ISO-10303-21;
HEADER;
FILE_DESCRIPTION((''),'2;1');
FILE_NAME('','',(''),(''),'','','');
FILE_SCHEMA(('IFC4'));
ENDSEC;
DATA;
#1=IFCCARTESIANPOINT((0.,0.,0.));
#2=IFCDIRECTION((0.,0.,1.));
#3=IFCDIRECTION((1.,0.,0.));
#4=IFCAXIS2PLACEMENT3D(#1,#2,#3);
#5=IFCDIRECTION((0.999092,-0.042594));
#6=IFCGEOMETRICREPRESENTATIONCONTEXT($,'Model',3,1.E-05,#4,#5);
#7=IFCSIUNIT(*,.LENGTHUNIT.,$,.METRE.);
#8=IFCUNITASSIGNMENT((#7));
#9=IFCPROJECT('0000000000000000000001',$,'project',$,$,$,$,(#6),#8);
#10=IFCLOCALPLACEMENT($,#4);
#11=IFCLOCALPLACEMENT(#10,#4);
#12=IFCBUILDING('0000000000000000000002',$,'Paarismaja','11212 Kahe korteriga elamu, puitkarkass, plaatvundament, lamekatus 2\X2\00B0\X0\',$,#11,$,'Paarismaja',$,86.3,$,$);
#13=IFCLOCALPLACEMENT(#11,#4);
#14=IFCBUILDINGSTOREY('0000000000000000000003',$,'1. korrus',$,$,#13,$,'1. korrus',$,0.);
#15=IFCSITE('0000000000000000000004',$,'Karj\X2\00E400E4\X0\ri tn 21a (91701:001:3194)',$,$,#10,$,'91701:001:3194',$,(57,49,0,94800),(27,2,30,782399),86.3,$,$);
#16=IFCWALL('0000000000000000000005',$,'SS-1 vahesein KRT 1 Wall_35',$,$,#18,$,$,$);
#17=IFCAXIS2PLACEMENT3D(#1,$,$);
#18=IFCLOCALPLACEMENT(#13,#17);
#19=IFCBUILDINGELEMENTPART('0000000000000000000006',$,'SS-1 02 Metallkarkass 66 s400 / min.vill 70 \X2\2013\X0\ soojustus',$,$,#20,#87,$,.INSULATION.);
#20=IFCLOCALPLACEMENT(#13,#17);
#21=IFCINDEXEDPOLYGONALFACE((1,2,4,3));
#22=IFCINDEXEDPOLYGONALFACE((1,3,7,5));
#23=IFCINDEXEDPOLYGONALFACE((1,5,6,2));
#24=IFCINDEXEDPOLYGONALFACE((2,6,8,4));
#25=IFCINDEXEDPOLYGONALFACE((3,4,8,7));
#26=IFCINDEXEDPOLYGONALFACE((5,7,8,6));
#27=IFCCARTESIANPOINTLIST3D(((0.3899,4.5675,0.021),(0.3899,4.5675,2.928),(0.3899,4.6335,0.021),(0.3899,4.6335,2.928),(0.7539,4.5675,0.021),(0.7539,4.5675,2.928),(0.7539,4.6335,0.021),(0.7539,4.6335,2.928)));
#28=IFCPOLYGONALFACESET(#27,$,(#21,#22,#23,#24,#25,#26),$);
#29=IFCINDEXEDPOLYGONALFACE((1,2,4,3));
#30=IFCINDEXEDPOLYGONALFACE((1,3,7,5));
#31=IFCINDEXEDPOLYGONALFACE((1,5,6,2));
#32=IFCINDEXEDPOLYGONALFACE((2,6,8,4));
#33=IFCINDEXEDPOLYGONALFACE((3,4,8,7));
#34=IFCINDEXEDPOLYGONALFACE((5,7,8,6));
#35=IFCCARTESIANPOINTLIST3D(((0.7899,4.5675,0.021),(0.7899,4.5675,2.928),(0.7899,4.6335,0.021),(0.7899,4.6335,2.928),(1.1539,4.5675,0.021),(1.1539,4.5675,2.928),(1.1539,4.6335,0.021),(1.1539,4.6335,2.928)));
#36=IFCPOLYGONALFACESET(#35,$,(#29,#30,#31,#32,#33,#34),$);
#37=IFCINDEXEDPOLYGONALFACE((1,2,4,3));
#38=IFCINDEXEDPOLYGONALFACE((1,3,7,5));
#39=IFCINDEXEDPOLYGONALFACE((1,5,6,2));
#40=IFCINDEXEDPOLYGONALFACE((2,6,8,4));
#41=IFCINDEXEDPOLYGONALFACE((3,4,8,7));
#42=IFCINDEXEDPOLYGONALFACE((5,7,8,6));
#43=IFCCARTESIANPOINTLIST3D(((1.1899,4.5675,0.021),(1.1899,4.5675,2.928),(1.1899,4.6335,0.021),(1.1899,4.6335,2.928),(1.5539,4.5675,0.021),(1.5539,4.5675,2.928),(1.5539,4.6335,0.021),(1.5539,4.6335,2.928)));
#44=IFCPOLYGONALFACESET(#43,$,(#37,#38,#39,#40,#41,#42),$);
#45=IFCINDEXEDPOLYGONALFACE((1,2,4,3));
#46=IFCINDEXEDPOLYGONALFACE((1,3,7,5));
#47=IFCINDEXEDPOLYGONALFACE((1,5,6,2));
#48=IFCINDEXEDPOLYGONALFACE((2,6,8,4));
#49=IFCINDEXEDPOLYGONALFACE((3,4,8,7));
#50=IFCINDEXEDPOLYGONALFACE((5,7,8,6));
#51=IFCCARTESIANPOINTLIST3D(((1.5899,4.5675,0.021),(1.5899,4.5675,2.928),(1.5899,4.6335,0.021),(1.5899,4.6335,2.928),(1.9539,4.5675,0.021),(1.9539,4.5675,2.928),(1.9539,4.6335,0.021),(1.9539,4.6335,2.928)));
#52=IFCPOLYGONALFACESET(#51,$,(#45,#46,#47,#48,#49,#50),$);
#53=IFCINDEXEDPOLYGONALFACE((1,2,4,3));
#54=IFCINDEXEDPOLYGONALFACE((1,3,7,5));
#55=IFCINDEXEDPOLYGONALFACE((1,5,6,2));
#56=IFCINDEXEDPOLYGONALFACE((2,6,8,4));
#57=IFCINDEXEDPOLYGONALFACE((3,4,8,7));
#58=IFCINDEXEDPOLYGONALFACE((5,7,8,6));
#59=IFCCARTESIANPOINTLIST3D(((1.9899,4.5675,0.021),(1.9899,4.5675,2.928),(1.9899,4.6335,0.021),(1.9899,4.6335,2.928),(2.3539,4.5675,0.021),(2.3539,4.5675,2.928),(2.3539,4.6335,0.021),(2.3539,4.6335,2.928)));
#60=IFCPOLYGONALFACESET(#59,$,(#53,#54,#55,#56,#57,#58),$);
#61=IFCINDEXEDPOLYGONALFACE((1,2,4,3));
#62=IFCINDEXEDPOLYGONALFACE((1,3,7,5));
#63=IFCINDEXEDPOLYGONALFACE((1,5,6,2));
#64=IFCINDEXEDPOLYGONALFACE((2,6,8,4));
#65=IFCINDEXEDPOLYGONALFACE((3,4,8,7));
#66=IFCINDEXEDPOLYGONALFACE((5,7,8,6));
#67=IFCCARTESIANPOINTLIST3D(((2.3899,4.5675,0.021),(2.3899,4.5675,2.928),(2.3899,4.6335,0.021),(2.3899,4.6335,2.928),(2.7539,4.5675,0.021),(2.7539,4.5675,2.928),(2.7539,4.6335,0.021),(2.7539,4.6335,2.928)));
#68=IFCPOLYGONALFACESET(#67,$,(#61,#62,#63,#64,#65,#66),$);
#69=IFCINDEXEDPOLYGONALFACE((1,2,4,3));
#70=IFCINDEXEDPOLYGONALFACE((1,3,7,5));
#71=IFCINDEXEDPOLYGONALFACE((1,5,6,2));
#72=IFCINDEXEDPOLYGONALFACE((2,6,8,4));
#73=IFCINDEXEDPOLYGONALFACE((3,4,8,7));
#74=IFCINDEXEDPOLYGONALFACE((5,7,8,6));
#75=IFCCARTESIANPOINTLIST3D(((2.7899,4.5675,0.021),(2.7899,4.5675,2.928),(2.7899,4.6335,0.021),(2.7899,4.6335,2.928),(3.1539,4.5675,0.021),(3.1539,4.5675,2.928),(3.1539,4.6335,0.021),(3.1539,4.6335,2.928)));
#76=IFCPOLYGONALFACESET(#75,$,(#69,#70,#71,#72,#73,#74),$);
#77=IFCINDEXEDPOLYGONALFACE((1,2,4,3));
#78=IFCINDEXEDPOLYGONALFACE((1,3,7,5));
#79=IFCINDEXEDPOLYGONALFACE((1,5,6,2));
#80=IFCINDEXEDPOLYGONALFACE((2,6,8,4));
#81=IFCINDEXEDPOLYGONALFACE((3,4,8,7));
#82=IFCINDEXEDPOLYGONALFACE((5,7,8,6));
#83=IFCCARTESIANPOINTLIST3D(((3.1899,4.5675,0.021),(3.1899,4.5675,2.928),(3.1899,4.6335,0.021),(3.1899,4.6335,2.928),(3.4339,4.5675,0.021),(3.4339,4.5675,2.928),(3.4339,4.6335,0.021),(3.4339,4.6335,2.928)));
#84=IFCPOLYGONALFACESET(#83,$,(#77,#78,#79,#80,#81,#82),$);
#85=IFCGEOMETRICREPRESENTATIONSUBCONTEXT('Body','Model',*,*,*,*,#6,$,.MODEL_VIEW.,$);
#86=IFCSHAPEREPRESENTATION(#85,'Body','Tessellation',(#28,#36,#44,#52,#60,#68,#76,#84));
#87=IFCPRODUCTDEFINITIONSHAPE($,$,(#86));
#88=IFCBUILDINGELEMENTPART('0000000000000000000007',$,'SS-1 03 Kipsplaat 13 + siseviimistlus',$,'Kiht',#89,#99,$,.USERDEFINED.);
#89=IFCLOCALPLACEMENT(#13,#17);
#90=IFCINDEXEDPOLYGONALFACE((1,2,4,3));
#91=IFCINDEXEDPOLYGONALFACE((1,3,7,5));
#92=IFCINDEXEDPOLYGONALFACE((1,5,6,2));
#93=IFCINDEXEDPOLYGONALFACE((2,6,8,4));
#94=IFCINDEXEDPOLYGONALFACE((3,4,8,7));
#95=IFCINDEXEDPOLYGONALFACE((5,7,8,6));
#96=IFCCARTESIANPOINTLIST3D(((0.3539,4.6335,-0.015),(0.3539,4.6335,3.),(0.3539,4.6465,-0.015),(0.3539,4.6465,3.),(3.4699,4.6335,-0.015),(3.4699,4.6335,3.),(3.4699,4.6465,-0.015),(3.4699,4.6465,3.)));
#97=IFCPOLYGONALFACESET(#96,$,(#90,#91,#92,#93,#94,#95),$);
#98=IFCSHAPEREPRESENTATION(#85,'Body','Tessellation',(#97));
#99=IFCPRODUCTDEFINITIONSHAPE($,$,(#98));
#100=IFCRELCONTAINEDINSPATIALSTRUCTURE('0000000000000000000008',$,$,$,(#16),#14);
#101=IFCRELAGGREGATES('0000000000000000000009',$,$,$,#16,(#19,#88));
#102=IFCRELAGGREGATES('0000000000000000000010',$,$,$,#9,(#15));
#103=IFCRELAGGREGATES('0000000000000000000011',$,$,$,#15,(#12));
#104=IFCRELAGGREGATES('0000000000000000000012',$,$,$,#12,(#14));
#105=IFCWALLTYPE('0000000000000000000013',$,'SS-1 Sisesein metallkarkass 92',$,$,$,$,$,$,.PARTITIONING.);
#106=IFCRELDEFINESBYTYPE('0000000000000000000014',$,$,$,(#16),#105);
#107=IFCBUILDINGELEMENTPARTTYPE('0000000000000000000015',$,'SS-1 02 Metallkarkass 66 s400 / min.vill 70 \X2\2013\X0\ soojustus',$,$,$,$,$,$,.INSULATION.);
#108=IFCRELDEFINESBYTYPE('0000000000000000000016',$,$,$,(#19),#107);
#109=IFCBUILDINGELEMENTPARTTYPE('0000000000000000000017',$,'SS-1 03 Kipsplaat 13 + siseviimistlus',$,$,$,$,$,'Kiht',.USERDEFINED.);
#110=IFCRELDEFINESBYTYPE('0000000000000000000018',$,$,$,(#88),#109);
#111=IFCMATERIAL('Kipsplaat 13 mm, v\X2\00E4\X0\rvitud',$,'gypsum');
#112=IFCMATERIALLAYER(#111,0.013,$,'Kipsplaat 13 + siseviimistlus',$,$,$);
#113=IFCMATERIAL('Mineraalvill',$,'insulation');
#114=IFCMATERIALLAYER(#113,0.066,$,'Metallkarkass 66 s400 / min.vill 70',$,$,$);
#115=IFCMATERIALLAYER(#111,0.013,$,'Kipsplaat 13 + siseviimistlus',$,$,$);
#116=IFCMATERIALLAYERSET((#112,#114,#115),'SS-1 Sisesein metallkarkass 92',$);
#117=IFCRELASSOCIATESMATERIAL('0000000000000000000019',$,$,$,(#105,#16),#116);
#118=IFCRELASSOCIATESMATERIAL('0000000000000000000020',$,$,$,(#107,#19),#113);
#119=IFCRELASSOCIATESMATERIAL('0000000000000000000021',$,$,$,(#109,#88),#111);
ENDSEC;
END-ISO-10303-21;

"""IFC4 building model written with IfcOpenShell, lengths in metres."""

from ifc_helpers import new_model, si_unit, direction, frame, origin_with_axes, place, context, subcontext, project, spatial, indexed_curve, outline, extrude, material, layer, layer_set, layer_usage, type_object, element, aggregate, save


model = new_model("IFC4")

# Units and contexts
model_context = context("Model", 3, precision=1e-05, world=origin_with_axes(), true_north=direction((0.999092, -0.042594)))
body_context = subcontext(model_context, "Body", "Model", "MODEL_VIEW")
ifc_project = project(units=[si_unit("LENGTHUNIT", "METRE")], contexts=[model_context])

# Site, building, storey
site_placement = place(None, origin_with_axes())
site = spatial("IfcSite", under=ifc_project, at=site_placement, Name="Karjääri tn 21a (91701:001:3194)", LongName="91701:001:3194", RefLatitude=(57, 49, 0, 94800), RefLongitude=(27, 2, 30, 782399), RefElevation=86.3)
building_placement = place(site_placement, origin_with_axes())
building = spatial("IfcBuilding", under=site, at=building_placement, Name="Paarismaja", Description="11212 Kahe korteriga elamu, puitkarkass, plaatvundament, lamekatus 2°", LongName="Paarismaja", ElevationOfRefHeight=86.3)
storey_placement = place(building_placement, origin_with_axes())
storey = spatial("IfcBuildingStorey", under=building, at=storey_placement, Name="1. korrus", LongName="1. korrus", Elevation=0.0)

# Wall
ifc_material_1 = material(Name="Kipsplaat 13 mm, värvitud", Category="gypsum")
ifc_layer_1 = layer(ifc_material_1, 0.013, Name="Kipsplaat 13 + siseviimistlus")
ifc_material_2 = material(Name="Mineraalvill", Category="insulation")
ifc_layer_2 = layer(ifc_material_2, 0.066, Name="Metallkarkass 66 s400 / min.vill 70")
ifc_layer_3 = layer(ifc_material_1, 0.013, Name="Kipsplaat 13 + siseviimistlus")
ifc_layer_set = layer_set([ifc_layer_1, ifc_layer_2, ifc_layer_3], Name="SS-1 Sisesein metallkarkass 92")
ifc_layer_usage = layer_usage(ifc_layer_set, "AXIS2", "POSITIVE", 0.0)
wall_type = type_object("IfcWallType", Name="SS-1 Sisesein metallkarkass 92", PredefinedType="PARTITIONING", material=ifc_layer_set)
wall_placement = place(storey_placement, frame((0.3539, 4.5545, 0.0), z_axis=(0.0, 0.0, 1.0), x_axis=(1.0, 0.0, 0.0)))
wall = element("IfcWall", 1, at=wall_placement, inside=storey, type_object=wall_type, material=ifc_layer_usage, Name="SS-1 vahesein KRT 1 Wall_35")

# Building element parts
building_element_part_type_1 = type_object("IfcBuildingElementPartType", Name="SS-1 02 Metallkarkass 66 s400 / min.vill 70 – soojustus", PredefinedType="INSULATION", material=ifc_material_2)
building_element_part_1_placement = place(wall_placement, origin_with_axes())
building_element_part_1 = element("IfcBuildingElementPart", 2, at=building_element_part_1_placement, type_object=building_element_part_type_1, material=ifc_material_2, Name="SS-1 02 Metallkarkass 66 s400 / min.vill 70 – soojustus", PredefinedType="INSULATION", context=body_context, shape_type="SweptSolid", body=[
    extrude(outline(indexed_curve([(0.036, 0.021), (0.036, 2.928), (0.4, 2.928), (0.4, 0.021), (0.036, 0.021)], self_intersect=False)), frame((0.0, 0.079, 0.0), z_axis=(0.0, -1.0, 0.0), x_axis=(1.0, 0.0, 0.0)), (0.0, 0.0, 1.0), 0.066),
    extrude(outline(indexed_curve([(0.436, 0.021), (0.436, 2.928), (0.8, 2.928), (0.8, 0.021), (0.436, 0.021)], self_intersect=False)), frame((0.0, 0.079, 0.0), z_axis=(0.0, -1.0, 0.0), x_axis=(1.0, 0.0, 0.0)), (0.0, 0.0, 1.0), 0.066),
    extrude(outline(indexed_curve([(0.836, 0.021), (0.836, 2.928), (1.2, 2.928), (1.2, 0.021), (0.836, 0.021)], self_intersect=False)), frame((0.0, 0.079, 0.0), z_axis=(0.0, -1.0, 0.0), x_axis=(1.0, 0.0, 0.0)), (0.0, 0.0, 1.0), 0.066),
    extrude(outline(indexed_curve([(1.236, 0.021), (1.236, 2.928), (1.6, 2.928), (1.6, 0.021), (1.236, 0.021)], self_intersect=False)), frame((0.0, 0.079, 0.0), z_axis=(0.0, -1.0, 0.0), x_axis=(1.0, 0.0, 0.0)), (0.0, 0.0, 1.0), 0.066),
    extrude(outline(indexed_curve([(2.0, 0.021), (1.636, 0.021), (1.636, 2.928), (2.0, 2.928), (2.0, 0.021)], self_intersect=False)), frame((0.0, 0.079, 0.0), z_axis=(0.0, -1.0, 0.0), x_axis=(1.0, 0.0, 0.0)), (0.0, 0.0, 1.0), 0.066),
    extrude(outline(indexed_curve([(2.4, 0.021), (2.036, 0.021), (2.036, 2.928), (2.4, 2.928), (2.4, 0.021)], self_intersect=False)), frame((0.0, 0.079, 0.0), z_axis=(0.0, -1.0, 0.0), x_axis=(1.0, 0.0, 0.0)), (0.0, 0.0, 1.0), 0.066),
    extrude(outline(indexed_curve([(2.8, 0.021), (2.436, 0.021), (2.436, 2.928), (2.8, 2.928), (2.8, 0.021)], self_intersect=False)), frame((0.0, 0.079, 0.0), z_axis=(0.0, -1.0, 0.0), x_axis=(1.0, 0.0, 0.0)), (0.0, 0.0, 1.0), 0.066),
    extrude(outline(indexed_curve([(3.08, 0.021), (2.836, 0.021), (2.836, 2.928), (3.08, 2.928), (3.08, 0.021)], self_intersect=False)), frame((0.0, 0.079, 0.0), z_axis=(0.0, -1.0, 0.0), x_axis=(1.0, 0.0, 0.0)), (0.0, 0.0, 1.0), 0.066),
])
building_element_part_type_2 = type_object("IfcBuildingElementPartType", Name="SS-1 03 Kipsplaat 13 + siseviimistlus", ElementType="Kiht", PredefinedType="USERDEFINED", material=ifc_material_1)
building_element_part_2_placement = place(wall_placement, origin_with_axes())
building_element_part_2 = element("IfcBuildingElementPart", 3, at=building_element_part_2_placement, type_object=building_element_part_type_2, material=ifc_material_1, Name="SS-1 03 Kipsplaat 13 + siseviimistlus", ObjectType="Kiht", PredefinedType="USERDEFINED", context=body_context, shape_type="SweptSolid", body=[
    extrude(outline(indexed_curve([(3.116, -0.015), (3.116, 3.0), (0.0, 3.0), (0.0, -0.015), (3.116, -0.015)], self_intersect=False)), frame((0.0, 0.092, 0.0), z_axis=(0.0, -1.0, 0.0), x_axis=(1.0, 0.0, 0.0)), (0.0, 0.0, 1.0), 0.013),
])
aggregate(wall, [building_element_part_1, building_element_part_2])

save(model, "model.ifc")
